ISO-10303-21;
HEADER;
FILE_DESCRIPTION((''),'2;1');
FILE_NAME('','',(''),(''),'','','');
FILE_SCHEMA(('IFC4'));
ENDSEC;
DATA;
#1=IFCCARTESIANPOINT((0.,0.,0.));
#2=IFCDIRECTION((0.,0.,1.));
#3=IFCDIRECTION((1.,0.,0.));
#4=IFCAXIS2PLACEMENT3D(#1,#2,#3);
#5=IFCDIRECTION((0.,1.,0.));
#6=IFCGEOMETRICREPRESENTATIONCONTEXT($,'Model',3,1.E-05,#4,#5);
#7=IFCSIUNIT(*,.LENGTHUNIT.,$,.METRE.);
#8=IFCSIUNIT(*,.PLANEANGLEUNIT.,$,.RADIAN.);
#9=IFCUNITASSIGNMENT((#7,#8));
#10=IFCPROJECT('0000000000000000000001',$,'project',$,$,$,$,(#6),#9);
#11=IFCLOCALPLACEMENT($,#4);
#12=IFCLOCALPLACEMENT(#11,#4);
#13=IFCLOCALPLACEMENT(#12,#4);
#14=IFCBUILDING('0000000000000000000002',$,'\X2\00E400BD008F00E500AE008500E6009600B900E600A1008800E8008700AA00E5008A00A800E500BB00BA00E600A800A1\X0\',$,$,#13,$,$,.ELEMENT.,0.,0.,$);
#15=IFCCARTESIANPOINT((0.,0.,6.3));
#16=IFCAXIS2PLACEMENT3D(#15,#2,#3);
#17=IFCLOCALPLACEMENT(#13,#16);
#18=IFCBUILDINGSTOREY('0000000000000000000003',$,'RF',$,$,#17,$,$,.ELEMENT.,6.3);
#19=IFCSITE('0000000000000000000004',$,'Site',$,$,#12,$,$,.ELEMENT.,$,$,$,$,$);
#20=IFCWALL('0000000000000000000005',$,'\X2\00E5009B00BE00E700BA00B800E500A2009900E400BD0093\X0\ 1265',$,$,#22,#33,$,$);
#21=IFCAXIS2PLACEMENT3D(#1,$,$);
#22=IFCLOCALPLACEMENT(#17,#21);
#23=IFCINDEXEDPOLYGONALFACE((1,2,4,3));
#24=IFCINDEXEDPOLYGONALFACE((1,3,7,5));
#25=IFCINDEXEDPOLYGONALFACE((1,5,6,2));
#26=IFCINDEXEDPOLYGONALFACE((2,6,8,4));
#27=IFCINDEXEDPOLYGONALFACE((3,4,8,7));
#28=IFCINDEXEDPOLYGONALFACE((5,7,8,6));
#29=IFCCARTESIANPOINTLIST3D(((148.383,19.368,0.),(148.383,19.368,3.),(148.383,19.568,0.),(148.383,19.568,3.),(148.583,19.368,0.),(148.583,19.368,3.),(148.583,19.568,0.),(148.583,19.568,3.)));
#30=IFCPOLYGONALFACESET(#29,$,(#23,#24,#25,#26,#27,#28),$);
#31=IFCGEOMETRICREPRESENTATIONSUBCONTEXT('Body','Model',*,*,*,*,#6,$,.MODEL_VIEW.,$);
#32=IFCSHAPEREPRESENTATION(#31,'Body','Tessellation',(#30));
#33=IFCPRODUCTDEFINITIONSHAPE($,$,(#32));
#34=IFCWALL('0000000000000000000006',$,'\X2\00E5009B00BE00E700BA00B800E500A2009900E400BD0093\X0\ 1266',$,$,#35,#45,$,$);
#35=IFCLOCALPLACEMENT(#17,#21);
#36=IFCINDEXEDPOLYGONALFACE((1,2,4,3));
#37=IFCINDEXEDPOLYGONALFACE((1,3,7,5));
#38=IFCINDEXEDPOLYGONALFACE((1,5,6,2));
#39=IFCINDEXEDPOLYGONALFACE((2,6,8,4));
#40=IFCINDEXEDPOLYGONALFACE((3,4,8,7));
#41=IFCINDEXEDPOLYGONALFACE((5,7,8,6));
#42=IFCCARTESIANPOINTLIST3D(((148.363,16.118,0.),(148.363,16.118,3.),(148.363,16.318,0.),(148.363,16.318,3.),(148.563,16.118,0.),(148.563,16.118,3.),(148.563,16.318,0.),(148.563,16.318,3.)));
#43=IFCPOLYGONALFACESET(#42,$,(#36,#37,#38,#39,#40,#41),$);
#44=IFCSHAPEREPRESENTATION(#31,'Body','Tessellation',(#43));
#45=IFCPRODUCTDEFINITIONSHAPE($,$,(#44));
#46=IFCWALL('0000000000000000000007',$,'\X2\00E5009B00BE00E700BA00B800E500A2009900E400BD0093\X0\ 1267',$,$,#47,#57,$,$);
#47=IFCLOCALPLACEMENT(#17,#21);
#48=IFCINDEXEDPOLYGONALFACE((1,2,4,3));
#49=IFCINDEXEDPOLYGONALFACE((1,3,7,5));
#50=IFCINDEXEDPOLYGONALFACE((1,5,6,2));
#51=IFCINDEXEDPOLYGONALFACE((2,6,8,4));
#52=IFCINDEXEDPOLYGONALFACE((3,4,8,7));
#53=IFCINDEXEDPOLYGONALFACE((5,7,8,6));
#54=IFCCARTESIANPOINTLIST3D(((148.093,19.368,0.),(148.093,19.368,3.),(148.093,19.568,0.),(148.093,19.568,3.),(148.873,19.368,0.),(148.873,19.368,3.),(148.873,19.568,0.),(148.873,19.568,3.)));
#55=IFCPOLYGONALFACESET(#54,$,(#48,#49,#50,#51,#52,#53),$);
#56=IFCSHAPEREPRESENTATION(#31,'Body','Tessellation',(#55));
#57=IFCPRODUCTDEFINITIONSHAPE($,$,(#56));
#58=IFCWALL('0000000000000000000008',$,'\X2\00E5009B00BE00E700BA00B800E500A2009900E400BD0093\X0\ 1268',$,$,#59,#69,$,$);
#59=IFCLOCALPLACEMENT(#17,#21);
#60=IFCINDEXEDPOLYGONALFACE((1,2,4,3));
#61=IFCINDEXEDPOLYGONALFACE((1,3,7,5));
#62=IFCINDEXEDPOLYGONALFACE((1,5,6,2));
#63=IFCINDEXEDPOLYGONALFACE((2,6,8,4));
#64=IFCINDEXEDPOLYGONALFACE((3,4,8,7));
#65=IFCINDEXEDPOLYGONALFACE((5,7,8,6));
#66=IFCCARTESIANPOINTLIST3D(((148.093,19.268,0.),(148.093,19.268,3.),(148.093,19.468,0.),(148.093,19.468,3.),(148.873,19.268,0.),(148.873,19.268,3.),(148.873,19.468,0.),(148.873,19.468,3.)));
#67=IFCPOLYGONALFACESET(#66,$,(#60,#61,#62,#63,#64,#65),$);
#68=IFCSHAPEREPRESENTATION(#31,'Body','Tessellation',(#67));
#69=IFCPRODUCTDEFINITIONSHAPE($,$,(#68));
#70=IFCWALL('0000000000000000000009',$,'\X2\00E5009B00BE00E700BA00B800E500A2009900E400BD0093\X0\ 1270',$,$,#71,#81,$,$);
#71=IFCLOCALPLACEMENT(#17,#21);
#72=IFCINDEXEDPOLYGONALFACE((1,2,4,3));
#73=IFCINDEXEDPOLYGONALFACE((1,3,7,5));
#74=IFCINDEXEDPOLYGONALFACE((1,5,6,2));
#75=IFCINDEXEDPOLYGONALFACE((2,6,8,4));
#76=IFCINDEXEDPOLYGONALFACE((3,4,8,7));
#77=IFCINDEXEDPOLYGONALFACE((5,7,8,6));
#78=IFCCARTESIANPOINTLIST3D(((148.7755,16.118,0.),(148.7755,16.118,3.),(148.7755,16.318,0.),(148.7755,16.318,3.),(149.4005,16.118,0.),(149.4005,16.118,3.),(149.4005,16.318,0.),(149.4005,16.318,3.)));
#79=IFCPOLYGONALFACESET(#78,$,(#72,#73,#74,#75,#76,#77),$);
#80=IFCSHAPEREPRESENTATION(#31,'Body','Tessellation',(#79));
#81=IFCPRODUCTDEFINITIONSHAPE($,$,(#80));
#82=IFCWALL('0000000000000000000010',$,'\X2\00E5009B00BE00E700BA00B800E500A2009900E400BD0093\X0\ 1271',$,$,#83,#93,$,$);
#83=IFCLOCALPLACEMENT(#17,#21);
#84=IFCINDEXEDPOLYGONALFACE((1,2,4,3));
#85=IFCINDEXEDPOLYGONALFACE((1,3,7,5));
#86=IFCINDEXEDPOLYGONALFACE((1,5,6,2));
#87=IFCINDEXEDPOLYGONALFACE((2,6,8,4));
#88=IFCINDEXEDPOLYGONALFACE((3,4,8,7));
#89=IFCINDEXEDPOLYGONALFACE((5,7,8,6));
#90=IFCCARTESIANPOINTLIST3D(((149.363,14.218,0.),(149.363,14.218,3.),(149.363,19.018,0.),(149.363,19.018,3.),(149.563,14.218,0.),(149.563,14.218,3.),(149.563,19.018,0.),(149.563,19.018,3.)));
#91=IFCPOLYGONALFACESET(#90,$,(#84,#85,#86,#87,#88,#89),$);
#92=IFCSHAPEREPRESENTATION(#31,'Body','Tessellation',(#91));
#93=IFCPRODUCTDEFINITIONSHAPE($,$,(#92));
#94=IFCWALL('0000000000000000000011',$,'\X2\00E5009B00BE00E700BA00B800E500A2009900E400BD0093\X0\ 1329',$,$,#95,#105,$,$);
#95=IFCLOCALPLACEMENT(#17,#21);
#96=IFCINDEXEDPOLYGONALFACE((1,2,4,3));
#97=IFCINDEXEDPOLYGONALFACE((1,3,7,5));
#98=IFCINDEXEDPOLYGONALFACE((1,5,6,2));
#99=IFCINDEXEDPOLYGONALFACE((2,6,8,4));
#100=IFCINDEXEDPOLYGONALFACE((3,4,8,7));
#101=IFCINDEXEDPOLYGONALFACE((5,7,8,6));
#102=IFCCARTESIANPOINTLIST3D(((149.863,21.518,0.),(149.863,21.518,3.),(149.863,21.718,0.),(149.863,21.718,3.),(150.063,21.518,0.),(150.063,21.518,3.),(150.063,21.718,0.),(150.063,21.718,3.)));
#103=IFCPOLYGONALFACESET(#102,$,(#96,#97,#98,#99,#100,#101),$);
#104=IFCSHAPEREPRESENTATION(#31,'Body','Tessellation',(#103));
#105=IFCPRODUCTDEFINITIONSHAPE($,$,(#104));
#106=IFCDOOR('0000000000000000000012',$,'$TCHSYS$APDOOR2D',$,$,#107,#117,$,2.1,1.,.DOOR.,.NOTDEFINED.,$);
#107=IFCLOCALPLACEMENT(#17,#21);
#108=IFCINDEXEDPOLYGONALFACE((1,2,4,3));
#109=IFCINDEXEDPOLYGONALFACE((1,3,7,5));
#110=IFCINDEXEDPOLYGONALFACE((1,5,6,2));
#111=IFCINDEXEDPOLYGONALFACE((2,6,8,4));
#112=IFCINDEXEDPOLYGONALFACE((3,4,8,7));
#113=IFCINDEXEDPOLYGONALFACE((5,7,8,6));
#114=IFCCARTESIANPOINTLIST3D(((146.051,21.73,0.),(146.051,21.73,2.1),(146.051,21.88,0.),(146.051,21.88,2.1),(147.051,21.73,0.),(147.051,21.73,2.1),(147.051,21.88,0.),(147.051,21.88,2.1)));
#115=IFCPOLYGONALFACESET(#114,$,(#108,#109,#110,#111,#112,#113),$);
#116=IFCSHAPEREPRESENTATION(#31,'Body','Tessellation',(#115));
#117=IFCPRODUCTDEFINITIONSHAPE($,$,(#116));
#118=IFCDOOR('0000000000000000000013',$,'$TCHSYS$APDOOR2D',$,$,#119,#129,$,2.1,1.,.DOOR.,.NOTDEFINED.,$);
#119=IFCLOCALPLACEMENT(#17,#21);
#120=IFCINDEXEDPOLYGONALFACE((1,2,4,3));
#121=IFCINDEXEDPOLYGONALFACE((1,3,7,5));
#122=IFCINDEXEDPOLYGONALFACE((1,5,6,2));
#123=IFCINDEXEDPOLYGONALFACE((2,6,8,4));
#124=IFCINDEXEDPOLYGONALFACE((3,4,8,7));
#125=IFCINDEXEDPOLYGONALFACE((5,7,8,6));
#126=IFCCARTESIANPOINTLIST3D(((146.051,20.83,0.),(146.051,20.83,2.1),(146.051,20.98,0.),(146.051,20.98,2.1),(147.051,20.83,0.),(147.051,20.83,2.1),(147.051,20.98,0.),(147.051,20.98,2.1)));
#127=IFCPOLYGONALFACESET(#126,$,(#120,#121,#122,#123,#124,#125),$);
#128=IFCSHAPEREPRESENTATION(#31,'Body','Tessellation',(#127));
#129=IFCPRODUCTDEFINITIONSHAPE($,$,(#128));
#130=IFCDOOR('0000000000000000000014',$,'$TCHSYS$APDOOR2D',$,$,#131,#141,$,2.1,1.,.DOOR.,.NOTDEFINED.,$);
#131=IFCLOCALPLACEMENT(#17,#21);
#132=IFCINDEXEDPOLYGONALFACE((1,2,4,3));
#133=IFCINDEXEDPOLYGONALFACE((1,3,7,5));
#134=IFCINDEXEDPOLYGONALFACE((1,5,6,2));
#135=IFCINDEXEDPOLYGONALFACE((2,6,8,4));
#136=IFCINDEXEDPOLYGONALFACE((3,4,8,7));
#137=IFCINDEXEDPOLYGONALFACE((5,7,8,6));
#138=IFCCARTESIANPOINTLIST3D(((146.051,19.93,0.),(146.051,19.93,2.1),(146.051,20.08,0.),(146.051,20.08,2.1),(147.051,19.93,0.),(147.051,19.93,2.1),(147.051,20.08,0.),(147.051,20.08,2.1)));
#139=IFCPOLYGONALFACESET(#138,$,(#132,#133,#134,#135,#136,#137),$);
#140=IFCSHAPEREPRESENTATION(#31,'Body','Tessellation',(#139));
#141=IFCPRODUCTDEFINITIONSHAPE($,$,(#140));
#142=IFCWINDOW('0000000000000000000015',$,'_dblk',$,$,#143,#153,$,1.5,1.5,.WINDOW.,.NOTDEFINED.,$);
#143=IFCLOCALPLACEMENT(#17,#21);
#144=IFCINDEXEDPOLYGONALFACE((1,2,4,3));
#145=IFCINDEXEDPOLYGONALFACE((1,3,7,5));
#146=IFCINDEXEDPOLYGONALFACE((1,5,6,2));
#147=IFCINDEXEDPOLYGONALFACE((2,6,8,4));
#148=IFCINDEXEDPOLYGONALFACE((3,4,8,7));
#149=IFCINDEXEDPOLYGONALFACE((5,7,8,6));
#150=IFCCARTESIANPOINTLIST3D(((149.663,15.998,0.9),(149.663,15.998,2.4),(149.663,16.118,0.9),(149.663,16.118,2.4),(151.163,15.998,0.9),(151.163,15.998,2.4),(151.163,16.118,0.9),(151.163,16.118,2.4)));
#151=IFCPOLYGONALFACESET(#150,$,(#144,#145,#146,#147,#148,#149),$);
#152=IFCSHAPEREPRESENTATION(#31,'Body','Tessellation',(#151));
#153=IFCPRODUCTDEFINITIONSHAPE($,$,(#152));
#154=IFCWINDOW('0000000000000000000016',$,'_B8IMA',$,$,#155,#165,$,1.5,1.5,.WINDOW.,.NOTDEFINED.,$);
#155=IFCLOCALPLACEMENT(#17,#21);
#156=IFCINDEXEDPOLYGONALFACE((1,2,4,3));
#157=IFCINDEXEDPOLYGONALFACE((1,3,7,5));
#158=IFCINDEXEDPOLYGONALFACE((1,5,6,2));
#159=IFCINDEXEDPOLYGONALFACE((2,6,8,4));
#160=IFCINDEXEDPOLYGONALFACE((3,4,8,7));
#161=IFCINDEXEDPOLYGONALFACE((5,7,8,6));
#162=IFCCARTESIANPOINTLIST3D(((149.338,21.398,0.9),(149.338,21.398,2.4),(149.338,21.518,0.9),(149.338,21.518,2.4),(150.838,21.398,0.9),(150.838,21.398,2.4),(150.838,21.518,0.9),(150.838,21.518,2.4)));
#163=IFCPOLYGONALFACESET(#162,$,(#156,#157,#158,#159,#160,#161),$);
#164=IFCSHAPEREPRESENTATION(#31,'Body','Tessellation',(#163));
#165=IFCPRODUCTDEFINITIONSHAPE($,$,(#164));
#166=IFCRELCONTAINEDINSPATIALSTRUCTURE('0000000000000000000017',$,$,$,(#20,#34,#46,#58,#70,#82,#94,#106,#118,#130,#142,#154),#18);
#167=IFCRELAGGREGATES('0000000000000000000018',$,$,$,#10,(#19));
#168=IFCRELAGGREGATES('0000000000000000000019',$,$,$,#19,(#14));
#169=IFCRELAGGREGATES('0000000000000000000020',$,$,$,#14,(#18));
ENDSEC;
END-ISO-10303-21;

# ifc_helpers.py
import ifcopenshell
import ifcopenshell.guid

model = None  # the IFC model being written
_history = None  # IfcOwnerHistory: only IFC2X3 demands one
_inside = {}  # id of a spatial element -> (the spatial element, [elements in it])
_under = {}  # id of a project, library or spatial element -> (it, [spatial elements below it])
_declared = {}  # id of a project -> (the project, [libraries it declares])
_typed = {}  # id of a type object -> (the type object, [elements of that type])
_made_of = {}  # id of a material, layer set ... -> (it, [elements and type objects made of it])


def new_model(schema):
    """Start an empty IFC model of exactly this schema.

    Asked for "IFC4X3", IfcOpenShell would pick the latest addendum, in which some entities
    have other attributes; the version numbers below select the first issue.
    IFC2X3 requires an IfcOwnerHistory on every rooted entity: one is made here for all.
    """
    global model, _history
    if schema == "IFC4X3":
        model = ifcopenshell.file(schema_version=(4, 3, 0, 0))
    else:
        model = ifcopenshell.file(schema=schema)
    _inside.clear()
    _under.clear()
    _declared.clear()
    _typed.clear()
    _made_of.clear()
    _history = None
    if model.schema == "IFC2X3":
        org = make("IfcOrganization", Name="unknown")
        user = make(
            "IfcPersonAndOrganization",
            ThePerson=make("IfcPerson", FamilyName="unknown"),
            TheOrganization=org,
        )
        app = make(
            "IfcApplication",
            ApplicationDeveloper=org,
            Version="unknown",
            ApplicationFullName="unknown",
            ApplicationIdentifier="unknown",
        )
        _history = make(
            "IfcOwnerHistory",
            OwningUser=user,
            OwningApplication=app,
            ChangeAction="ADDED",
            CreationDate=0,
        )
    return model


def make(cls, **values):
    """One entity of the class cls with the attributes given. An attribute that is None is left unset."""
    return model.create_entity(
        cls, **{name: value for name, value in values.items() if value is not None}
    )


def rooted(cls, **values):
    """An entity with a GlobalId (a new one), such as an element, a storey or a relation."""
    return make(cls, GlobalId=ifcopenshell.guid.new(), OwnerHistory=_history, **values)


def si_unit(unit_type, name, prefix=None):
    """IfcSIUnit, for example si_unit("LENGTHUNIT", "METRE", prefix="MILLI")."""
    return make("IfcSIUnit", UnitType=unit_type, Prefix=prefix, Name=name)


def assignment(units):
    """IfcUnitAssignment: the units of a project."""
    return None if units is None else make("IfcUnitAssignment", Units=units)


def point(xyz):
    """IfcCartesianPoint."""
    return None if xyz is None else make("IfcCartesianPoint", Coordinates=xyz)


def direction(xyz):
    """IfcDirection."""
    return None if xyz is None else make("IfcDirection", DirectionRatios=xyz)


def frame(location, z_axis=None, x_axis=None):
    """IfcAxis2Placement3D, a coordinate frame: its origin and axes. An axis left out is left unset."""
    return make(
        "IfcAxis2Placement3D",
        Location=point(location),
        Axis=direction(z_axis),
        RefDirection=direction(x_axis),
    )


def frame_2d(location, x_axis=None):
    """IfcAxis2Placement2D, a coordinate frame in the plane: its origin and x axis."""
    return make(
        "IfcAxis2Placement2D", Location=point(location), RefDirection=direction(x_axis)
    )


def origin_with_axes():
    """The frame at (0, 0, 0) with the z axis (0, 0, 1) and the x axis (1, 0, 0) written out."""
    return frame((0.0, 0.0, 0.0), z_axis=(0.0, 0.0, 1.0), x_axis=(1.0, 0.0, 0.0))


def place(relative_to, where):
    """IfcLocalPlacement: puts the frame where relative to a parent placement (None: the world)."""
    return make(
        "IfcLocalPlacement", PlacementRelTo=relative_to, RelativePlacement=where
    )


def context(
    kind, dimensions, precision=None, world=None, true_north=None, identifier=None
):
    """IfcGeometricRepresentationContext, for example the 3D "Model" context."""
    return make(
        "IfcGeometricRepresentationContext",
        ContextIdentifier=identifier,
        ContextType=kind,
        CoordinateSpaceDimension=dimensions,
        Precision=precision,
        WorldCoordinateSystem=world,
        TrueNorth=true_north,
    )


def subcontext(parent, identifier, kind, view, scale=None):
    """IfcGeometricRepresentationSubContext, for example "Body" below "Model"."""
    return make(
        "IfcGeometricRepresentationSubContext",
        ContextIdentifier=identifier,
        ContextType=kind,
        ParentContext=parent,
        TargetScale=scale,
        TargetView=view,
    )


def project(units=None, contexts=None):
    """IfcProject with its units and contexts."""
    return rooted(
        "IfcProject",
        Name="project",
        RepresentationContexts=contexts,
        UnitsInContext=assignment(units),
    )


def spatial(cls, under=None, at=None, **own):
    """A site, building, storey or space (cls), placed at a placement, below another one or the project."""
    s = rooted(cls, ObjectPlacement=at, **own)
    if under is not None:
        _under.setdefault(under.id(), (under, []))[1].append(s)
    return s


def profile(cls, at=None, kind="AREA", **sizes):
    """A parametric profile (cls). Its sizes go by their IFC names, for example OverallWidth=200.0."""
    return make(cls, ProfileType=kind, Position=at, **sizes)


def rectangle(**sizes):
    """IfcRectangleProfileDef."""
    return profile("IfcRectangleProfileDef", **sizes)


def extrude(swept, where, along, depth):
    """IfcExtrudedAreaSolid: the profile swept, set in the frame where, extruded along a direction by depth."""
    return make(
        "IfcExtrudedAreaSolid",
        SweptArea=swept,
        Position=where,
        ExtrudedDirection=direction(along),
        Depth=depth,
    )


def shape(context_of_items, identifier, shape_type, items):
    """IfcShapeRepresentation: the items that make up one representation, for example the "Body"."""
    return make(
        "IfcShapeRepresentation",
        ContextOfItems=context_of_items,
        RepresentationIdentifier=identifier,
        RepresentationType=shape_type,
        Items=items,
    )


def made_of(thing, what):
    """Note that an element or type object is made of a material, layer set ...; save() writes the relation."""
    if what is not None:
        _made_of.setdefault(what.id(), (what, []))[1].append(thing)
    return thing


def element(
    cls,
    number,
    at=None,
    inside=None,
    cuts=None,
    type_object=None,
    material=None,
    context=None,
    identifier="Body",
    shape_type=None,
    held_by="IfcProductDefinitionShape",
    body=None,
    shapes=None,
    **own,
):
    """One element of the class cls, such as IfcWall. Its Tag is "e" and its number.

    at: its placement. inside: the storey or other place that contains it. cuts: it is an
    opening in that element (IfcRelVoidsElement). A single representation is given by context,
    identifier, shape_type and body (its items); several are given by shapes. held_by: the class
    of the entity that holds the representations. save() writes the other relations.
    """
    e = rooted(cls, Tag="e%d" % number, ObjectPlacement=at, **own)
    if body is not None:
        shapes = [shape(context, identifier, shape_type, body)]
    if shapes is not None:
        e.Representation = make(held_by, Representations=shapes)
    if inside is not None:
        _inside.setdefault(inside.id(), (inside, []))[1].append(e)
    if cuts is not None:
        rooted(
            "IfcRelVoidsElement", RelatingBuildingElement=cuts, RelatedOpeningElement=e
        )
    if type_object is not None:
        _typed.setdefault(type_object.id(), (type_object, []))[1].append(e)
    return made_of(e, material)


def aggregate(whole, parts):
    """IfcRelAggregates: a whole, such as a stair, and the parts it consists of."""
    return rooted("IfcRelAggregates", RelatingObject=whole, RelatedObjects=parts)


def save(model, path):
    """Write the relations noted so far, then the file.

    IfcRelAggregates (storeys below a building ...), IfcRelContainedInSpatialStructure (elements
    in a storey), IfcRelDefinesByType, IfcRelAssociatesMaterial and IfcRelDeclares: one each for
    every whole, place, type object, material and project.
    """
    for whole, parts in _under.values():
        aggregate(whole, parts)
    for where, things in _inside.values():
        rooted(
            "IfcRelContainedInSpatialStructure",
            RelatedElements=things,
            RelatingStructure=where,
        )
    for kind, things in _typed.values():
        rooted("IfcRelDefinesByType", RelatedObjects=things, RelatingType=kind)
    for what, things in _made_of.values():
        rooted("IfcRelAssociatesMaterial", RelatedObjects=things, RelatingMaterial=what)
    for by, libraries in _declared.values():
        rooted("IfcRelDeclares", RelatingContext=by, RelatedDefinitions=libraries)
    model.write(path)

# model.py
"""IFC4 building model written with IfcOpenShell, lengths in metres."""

from ifc_helpers import new_model, si_unit, direction, frame, frame_2d, origin_with_axes, place, context, subcontext, project, spatial, rectangle, extrude, element, save


model = new_model("IFC4")

# Units and contexts
model_context = context("Model", 3, precision=1e-05, world=origin_with_axes(), true_north=direction((0.0, 1.0, 0.0)))
body_context = subcontext(model_context, "Body", "Model", "MODEL_VIEW")
ifc_project = project(units=[si_unit("LENGTHUNIT", "METRE"), si_unit("PLANEANGLEUNIT", "RADIAN")], contexts=[model_context])

# Site, building, storey
placement = place(None, origin_with_axes())
site_placement = place(placement, origin_with_axes())
site = spatial("IfcSite", under=ifc_project, at=site_placement, Name="Site", CompositionType="ELEMENT")
building_placement = place(site_placement, origin_with_axes())
building = spatial("IfcBuilding", under=site, at=building_placement, Name="ä½\u008få®\u0085æ\u0096¹æ¡\u0088è\u0087ªå\u008a¨å»ºæ¨¡", CompositionType="ELEMENT", ElevationOfRefHeight=0.0, ElevationOfTerrain=0.0)
storey_placement = place(building_placement, frame((0.0, 0.0, 6.3), z_axis=(0.0, 0.0, 1.0), x_axis=(1.0, 0.0, 0.0)))
storey = spatial("IfcBuildingStorey", under=building, at=storey_placement, Name="RF", CompositionType="ELEMENT", Elevation=6.3)

# Walls
for number, where, z_axis, x_axis, name in (
    (1, (148.483, 19.468, 0.0), (0.0, 0.0, 1.0), (0.0, -1.0, 0.0), "å\u009b¾çº¸å¢\u0099ä½\u0093 1265"),
    (2, (148.463, 16.218, 0.0), (0.0, 0.0, 1.0), (0.0, -1.0, 0.0), "å\u009b¾çº¸å¢\u0099ä½\u0093 1266"),
):
    element("IfcWall", number, at=place(storey_placement, frame(where, z_axis=z_axis, x_axis=x_axis)), inside=storey, Name=name, context=body_context, shape_type="SweptSolid", body=[
        extrude(rectangle(XDim=0.2, YDim=0.2, at=frame_2d((0.0, 0.0), x_axis=(1.0, 0.0, 0.0))), frame((0.0, 0.0, 0.0), z_axis=(0.0, 0.0, 1.0)), (0.0, 0.0, 1.0), 3.0),
    ])
for number, where, z_axis, x_axis, name in (
    (3, (148.483, 19.468, 0.0), (0.0, 0.0, 1.0), (1.0, 0.0, 0.0), "å\u009b¾çº¸å¢\u0099ä½\u0093 1267"),
    (4, (148.483, 19.368, 0.0), (0.0, 0.0, 1.0), (1.0, 0.0, 0.0), "å\u009b¾çº¸å¢\u0099ä½\u0093 1268"),
):
    element("IfcWall", number, at=place(storey_placement, frame(where, z_axis=z_axis, x_axis=x_axis)), inside=storey, Name=name, context=body_context, shape_type="SweptSolid", body=[
        extrude(rectangle(XDim=0.78, YDim=0.2, at=frame_2d((0.0, 0.0), x_axis=(1.0, 0.0, 0.0))), frame((0.0, 0.0, 0.0), z_axis=(0.0, 0.0, 1.0)), (0.0, 0.0, 1.0), 3.0),
    ])
wall_1_placement = place(storey_placement, frame((149.088, 16.218, 0.0), z_axis=(0.0, 0.0, 1.0), x_axis=(-1.0, 0.0, 0.0)))
element("IfcWall", 5, at=wall_1_placement, inside=storey, Name="å\u009b¾çº¸å¢\u0099ä½\u0093 1270", context=body_context, shape_type="SweptSolid", body=[
    extrude(rectangle(XDim=0.625, YDim=0.2, at=frame_2d((0.0, 0.0), x_axis=(1.0, 0.0, 0.0))), frame((0.0, 0.0, 0.0), z_axis=(0.0, 0.0, 1.0)), (0.0, 0.0, 1.0), 3.0),
])
wall_2_placement = place(storey_placement, frame((149.463, 16.618, 0.0), z_axis=(0.0, 0.0, 1.0), x_axis=(0.0, 1.0, 0.0)))
element("IfcWall", 6, at=wall_2_placement, inside=storey, Name="å\u009b¾çº¸å¢\u0099ä½\u0093 1271", context=body_context, shape_type="SweptSolid", body=[
    extrude(rectangle(XDim=4.8, YDim=0.2, at=frame_2d((0.0, 0.0), x_axis=(1.0, 0.0, 0.0))), frame((0.0, 0.0, 0.0), z_axis=(0.0, 0.0, 1.0)), (0.0, 0.0, 1.0), 3.0),
])
wall_3_placement = place(storey_placement, frame((149.963, 21.618, 0.0), z_axis=(0.0, 0.0, 1.0), x_axis=(0.0, -1.0, 0.0)))
element("IfcWall", 7, at=wall_3_placement, inside=storey, Name="å\u009b¾çº¸å¢\u0099ä½\u0093 1329", context=body_context, shape_type="SweptSolid", body=[
    extrude(rectangle(XDim=0.2, YDim=0.2, at=frame_2d((0.0, 0.0), x_axis=(1.0, 0.0, 0.0))), frame((0.0, 0.0, 0.0), z_axis=(0.0, 0.0, 1.0)), (0.0, 0.0, 1.0), 3.0),
])

# Doors
for number, where, z_axis, x_axis, name in (
    (8, (146.551, 21.805, 0.0), (0.0, 0.0, 1.0), (1.0, 0.0, 0.0), "$TCHSYS$APDOOR2D"),
    (9, (146.551, 20.905, 0.0), (0.0, 0.0, 1.0), (1.0, 0.0, 0.0), "$TCHSYS$APDOOR2D"),
    (10, (146.551, 20.005, 0.0), (0.0, 0.0, 1.0), (1.0, 0.0, 0.0), "$TCHSYS$APDOOR2D"),
):
    element("IfcDoor", number, at=place(storey_placement, frame(where, z_axis=z_axis, x_axis=x_axis)), inside=storey, Name=name, OperationType="NOTDEFINED", OverallHeight=2.1, OverallWidth=1.0, PredefinedType="DOOR", context=body_context, shape_type="SweptSolid", body=[
        extrude(rectangle(XDim=1.0, YDim=0.15, at=frame_2d((0.0, 0.0), x_axis=(1.0, 0.0, 0.0))), frame((0.0, 0.0, 0.0), z_axis=(0.0, 0.0, 1.0)), (0.0, 0.0, 1.0), 2.1),
    ])

# Windows
for number, where, z_axis, x_axis, name in (
    (11, (150.413, 16.058, 0.9), (0.0, 0.0, 1.0), (1.0, 0.0, 0.0), "_dblk"),
    (12, (150.088, 21.458, 0.9), (0.0, 0.0, 1.0), (1.0, 0.0, 0.0), "_B8IMA"),
):
    element("IfcWindow", number, at=place(storey_placement, frame(where, z_axis=z_axis, x_axis=x_axis)), inside=storey, Name=name, OverallHeight=1.5, OverallWidth=1.5, PartitioningType="NOTDEFINED", PredefinedType="WINDOW", context=body_context, shape_type="SweptSolid", body=[
        extrude(rectangle(XDim=1.5, YDim=0.12, at=frame_2d((0.0, 0.0), x_axis=(1.0, 0.0, 0.0))), frame((0.0, 0.0, 0.0), z_axis=(0.0, 0.0, 1.0)), (0.0, 0.0, 1.0), 1.5),
    ])

save(model, "model.ifc")
